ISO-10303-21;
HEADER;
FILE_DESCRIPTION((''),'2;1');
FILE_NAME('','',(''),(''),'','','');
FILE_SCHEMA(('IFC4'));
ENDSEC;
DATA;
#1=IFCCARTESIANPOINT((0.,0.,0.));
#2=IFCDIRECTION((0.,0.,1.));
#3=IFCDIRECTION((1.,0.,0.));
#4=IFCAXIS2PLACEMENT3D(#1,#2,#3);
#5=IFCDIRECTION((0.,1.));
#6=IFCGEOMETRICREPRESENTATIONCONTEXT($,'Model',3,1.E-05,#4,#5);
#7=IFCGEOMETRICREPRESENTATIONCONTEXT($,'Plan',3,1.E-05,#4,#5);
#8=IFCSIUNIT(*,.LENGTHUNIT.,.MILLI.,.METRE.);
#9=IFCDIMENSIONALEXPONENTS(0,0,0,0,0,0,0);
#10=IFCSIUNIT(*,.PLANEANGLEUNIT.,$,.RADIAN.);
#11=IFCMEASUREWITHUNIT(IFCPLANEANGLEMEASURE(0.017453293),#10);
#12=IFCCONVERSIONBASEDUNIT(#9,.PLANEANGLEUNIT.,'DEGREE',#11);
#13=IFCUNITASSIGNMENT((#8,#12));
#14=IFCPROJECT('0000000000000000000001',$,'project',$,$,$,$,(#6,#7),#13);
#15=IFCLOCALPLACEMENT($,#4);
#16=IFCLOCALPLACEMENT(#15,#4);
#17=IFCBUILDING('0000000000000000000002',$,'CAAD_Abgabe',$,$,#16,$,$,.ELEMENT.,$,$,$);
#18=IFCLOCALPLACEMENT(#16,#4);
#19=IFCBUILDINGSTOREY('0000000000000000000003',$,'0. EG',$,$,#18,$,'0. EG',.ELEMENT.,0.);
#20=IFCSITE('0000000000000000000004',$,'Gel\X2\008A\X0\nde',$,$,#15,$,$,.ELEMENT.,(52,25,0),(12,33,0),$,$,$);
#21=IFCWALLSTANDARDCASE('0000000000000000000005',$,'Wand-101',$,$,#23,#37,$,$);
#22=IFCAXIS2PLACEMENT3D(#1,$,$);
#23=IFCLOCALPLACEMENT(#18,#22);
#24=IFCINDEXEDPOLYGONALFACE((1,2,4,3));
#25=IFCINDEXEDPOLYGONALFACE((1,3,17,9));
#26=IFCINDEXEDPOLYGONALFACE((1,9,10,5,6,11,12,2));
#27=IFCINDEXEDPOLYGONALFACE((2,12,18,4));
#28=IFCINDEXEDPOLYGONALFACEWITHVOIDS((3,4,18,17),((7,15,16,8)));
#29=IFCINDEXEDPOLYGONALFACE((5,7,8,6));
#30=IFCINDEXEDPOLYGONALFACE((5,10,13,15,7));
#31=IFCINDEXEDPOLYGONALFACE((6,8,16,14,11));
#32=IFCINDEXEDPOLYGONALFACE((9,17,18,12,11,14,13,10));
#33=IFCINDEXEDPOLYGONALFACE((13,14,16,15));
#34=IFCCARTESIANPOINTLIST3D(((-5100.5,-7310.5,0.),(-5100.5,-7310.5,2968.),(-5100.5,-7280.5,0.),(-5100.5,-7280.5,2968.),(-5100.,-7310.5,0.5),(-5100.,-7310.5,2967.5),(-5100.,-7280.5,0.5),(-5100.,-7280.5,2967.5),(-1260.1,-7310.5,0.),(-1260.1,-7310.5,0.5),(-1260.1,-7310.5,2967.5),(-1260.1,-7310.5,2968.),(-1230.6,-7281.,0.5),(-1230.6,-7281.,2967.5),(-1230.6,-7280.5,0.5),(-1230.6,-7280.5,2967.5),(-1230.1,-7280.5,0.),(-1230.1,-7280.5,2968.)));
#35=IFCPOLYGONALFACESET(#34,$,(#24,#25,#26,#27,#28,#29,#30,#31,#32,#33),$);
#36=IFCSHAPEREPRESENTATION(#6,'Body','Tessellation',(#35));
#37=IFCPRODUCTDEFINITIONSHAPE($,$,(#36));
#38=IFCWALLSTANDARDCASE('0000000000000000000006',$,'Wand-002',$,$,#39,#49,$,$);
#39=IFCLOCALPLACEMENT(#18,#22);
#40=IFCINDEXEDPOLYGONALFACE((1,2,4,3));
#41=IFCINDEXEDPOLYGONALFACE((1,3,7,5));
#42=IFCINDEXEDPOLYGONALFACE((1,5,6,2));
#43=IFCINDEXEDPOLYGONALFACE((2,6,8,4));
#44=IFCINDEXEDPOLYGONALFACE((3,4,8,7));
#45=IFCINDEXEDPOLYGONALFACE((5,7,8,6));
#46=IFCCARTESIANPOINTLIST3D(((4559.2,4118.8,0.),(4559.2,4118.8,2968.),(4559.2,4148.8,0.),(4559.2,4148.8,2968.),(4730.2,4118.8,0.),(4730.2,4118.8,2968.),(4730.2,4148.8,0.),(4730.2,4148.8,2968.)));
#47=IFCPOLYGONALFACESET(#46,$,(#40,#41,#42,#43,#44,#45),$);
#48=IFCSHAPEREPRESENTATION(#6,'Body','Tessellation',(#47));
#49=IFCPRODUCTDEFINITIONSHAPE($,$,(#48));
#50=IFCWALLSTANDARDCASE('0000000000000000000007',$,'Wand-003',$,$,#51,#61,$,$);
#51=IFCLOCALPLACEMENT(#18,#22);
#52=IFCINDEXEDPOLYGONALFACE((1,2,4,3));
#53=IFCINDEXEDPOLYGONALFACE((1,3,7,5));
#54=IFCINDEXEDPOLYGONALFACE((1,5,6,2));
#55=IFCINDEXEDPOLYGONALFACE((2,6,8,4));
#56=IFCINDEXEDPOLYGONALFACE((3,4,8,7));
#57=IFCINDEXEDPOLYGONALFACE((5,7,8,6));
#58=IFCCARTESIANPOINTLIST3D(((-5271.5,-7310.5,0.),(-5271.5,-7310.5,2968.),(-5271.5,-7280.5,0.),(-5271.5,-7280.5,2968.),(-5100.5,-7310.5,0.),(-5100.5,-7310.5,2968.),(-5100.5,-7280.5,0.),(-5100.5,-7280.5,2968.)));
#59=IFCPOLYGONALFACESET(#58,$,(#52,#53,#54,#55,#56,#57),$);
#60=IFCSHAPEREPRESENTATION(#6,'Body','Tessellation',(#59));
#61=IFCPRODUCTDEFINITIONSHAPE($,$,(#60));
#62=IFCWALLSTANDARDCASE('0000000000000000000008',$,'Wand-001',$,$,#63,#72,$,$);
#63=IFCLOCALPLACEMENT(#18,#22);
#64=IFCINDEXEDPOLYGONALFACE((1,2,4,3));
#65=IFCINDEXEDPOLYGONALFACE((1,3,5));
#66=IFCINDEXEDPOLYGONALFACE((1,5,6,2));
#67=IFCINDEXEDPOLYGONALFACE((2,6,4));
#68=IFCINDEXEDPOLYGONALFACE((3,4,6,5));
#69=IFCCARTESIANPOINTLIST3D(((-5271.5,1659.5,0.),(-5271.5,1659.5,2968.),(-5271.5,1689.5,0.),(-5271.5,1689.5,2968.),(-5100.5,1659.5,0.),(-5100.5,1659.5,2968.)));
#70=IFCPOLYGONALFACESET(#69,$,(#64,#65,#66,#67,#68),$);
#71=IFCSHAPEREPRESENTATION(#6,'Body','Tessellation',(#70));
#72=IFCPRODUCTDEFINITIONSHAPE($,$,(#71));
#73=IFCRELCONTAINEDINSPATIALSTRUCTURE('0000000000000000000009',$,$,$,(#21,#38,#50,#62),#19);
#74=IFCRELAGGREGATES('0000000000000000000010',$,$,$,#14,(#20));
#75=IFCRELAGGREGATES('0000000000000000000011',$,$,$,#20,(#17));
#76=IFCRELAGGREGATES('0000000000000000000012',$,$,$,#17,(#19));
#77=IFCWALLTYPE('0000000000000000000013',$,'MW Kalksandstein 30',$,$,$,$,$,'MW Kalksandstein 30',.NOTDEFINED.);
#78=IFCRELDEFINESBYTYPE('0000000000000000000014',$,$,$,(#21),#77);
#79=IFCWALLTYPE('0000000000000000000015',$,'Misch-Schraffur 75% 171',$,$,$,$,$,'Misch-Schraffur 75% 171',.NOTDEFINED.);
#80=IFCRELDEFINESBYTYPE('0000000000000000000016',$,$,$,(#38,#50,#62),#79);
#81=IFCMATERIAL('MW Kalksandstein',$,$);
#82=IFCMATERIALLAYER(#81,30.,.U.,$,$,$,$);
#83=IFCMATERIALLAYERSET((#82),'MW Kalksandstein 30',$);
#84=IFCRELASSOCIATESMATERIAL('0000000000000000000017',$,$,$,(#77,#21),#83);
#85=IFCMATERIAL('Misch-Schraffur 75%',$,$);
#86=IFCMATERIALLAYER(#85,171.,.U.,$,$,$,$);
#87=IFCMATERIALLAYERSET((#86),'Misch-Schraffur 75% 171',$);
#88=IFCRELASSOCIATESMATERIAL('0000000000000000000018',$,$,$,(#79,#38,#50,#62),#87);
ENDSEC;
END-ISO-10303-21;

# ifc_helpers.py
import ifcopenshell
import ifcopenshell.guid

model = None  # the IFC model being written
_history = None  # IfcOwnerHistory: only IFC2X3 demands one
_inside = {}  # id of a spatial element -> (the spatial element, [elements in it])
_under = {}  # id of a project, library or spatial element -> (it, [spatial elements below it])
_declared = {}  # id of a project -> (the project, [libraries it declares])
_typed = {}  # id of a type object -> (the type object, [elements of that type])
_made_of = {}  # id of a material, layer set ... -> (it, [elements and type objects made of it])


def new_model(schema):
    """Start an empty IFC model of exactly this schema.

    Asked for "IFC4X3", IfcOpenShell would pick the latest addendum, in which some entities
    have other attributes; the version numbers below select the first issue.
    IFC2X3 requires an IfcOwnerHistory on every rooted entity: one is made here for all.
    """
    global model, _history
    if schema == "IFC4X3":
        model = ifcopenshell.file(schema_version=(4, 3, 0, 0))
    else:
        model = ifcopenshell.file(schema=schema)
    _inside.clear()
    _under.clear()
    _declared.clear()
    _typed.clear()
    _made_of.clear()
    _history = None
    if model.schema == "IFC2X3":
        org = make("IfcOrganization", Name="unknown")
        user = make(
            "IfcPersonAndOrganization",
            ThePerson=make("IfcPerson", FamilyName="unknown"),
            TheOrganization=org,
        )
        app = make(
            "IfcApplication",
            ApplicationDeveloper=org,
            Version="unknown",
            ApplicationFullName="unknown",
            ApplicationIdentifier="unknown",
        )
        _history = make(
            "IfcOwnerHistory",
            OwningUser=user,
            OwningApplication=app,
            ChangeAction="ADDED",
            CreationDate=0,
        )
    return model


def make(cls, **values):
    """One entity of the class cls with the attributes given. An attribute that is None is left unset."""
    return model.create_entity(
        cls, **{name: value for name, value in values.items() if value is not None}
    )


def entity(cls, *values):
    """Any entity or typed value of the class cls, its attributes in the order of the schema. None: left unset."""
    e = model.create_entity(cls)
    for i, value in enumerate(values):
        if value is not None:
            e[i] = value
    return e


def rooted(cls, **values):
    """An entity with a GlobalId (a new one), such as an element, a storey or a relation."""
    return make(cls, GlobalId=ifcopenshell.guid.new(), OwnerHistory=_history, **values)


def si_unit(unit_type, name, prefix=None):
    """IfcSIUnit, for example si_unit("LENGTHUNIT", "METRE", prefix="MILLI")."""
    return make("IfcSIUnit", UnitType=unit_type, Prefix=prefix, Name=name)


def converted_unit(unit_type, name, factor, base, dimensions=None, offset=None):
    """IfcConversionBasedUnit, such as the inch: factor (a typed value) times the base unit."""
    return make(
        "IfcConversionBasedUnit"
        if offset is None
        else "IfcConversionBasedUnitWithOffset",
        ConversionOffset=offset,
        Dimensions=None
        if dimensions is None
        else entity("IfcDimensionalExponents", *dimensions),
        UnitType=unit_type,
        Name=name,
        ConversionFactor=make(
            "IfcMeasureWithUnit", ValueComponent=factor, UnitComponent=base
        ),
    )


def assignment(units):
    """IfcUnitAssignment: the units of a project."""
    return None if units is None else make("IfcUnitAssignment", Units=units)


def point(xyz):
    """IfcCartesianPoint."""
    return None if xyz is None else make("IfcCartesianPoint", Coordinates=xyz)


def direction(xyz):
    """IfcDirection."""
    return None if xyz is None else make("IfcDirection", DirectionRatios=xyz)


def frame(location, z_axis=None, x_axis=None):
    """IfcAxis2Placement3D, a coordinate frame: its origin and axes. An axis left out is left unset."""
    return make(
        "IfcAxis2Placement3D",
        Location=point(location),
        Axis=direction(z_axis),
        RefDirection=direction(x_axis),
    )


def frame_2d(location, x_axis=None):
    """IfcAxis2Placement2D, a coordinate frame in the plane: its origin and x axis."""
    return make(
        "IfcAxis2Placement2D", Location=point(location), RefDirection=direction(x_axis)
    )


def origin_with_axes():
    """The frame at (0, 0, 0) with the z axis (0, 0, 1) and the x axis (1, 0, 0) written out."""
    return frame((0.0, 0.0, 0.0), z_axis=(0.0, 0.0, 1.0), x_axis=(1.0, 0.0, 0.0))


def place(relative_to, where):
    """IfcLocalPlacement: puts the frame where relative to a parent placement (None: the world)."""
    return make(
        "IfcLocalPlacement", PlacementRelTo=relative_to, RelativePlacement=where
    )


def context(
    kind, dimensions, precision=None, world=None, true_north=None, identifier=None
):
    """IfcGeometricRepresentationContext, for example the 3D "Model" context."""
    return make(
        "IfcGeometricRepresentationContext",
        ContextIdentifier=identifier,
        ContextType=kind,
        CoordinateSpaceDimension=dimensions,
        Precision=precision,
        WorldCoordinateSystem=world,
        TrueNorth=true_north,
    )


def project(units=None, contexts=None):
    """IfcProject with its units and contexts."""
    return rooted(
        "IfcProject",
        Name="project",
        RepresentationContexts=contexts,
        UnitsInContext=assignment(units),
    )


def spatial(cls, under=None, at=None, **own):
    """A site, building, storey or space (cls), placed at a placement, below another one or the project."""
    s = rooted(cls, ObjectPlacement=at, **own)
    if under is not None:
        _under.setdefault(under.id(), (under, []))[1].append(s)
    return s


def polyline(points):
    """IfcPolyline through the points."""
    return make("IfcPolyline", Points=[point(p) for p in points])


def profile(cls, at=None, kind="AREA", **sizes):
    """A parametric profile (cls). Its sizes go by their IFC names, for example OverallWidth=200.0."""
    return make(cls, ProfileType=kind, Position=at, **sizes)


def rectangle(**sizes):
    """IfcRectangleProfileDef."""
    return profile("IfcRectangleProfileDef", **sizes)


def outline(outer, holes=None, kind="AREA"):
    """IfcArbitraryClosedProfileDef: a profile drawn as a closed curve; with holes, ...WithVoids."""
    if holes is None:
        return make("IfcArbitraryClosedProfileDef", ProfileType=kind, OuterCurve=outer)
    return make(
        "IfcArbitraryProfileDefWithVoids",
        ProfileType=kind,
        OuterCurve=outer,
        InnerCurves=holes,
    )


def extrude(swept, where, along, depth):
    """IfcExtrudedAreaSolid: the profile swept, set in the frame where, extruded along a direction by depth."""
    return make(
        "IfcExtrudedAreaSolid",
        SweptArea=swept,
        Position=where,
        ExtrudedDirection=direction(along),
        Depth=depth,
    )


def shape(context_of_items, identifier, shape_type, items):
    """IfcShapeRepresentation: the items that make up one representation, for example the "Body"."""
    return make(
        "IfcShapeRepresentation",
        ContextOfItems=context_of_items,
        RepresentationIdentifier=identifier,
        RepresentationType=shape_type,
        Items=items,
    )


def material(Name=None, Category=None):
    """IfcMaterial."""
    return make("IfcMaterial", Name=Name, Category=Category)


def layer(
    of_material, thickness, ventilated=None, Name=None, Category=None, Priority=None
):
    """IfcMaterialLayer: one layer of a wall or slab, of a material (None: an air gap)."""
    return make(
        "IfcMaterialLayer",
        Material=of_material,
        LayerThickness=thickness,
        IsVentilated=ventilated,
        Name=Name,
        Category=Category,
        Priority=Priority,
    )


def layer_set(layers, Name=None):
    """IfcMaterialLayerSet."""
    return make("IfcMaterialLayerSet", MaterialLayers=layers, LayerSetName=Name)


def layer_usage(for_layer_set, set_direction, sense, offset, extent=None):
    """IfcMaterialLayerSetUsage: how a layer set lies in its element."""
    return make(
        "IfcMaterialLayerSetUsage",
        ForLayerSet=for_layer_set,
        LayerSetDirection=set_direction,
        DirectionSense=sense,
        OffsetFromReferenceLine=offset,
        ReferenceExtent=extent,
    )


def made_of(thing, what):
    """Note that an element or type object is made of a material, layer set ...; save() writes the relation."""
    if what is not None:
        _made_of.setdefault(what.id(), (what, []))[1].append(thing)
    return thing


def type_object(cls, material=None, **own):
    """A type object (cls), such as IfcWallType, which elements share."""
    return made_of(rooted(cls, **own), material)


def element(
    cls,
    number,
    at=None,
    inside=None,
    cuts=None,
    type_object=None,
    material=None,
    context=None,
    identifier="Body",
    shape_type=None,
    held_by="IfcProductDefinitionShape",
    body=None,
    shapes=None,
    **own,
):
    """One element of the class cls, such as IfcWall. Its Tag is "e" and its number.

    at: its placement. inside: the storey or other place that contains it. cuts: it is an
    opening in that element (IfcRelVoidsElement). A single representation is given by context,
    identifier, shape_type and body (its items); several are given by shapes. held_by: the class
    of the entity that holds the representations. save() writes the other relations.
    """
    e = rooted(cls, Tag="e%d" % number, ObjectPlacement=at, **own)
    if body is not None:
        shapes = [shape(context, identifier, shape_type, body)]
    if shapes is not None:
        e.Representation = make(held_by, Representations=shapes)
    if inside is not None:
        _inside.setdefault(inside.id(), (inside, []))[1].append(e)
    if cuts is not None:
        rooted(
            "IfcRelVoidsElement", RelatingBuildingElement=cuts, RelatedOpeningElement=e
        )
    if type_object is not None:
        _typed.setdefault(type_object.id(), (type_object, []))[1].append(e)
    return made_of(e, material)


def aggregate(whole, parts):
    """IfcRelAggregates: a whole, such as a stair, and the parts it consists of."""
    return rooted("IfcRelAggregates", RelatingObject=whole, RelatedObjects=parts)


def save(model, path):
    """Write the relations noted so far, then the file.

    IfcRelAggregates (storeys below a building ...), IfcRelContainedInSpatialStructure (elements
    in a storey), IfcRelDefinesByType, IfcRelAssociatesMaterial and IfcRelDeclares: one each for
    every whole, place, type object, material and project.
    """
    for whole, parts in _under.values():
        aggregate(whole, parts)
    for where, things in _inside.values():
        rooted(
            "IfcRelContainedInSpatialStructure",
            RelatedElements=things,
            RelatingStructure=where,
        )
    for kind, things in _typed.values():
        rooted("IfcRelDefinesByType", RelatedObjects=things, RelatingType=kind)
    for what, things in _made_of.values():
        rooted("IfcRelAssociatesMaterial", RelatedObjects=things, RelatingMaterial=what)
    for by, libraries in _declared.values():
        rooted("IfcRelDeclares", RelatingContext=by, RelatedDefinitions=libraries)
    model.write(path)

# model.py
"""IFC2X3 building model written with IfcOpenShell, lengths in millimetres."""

from ifc_helpers import new_model, entity, si_unit, converted_unit, direction, frame, frame_2d, origin_with_axes, place, context, project, spatial, polyline, rectangle, outline, extrude, material, layer, layer_set, layer_usage, type_object, element, save


model = new_model("IFC2X3")

# Units and contexts
model_context = context("Model", 3, precision=1e-05, world=origin_with_axes(), true_north=direction((0.0, 1.0)))
plan_context = context("Plan", 3, precision=1e-05, world=origin_with_axes(), true_north=direction((0.0, 1.0)))
ifc_project = project(units=[si_unit("LENGTHUNIT", "METRE", prefix="MILLI"), converted_unit("PLANEANGLEUNIT", "DEGREE", entity("IfcPlaneAngleMeasure", 0.017453293), si_unit("PLANEANGLEUNIT", "RADIAN"), dimensions=[0, 0, 0, 0, 0, 0, 0])], contexts=[model_context, plan_context])

# Site, building, storey
site_placement = place(None, origin_with_axes())
site = spatial("IfcSite", under=ifc_project, at=site_placement, Name="Gel\u008ande", CompositionType="ELEMENT", RefLatitude=(52, 25, 0), RefLongitude=(12, 33, 0))
building_placement = place(site_placement, origin_with_axes())
building = spatial("IfcBuilding", under=site, at=building_placement, Name="CAAD_Abgabe", CompositionType="ELEMENT")
storey_placement = place(building_placement, origin_with_axes())
storey = spatial("IfcBuildingStorey", under=building, at=storey_placement, Name="0. EG", LongName="0. EG", CompositionType="ELEMENT", Elevation=0.0)

# Shared definitions
ifc_material_1 = material(Name="Misch-Schraffur 75%")

# Wall, opening
ifc_material_2 = material(Name="MW Kalksandstein")
ifc_layer_1 = layer(ifc_material_2, 30.0, ventilated="UNKNOWN")
ifc_layer_set_1 = layer_set([ifc_layer_1], Name="MW Kalksandstein 30")
wall_type_1 = type_object("IfcWallType", Name="MW Kalksandstein 30", ElementType="MW Kalksandstein 30", PredefinedType="NOTDEFINED", material=ifc_layer_set_1)
ifc_layer_usage_1 = layer_usage(ifc_layer_set_1, "AXIS2", "NEGATIVE", 0.0)
wall_1_placement = place(storey_placement, frame((-5100.5, -7280.5, 0.0), z_axis=(0.0, 0.0, 1.0), x_axis=(1.0, 0.0, 0.0)))
wall_1 = element("IfcWallStandardCase", 1, at=wall_1_placement, inside=storey, type_object=wall_type_1, material=ifc_layer_usage_1, Name="Wand-101", context=model_context, shape_type="SweptSolid", body=[
    extrude(outline(polyline([(0.0, -30.0), (3840.4, -30.0), (3870.4, 0.0), (0.0, 0.0), (0.0, -30.0)])), origin_with_axes(), (0.0, 0.0, 1.0), 2968.0),
])
opening_1_placement = place(wall_1_placement, frame((1935.2, -30.0, 0.0), z_axis=(0.0, 0.0, 1.0), x_axis=(1.0, 0.0, 0.0)))
element("IfcOpeningElement", 2, at=opening_1_placement, cuts=wall_1, ObjectType="Opening", context=model_context, shape_type="SweptSolid", body=[
    extrude(rectangle(XDim=3869.4, YDim=2967.0, at=frame_2d((0.0, 1484.0), x_axis=(1.0, 0.0))), frame((0.0, 0.0, 0.0), z_axis=(0.0, 1.0, 0.0), x_axis=(-1.0, 0.0, 0.0)), (0.0, 0.0, 1.0), 30.0),
])

# Walls
ifc_layer_2 = layer(ifc_material_1, 171.0, ventilated="UNKNOWN")
ifc_layer_set_2 = layer_set([ifc_layer_2], Name="Misch-Schraffur 75% 171")
ifc_layer_usage_2 = layer_usage(ifc_layer_set_2, "AXIS2", "NEGATIVE", 0.0)
wall_type_2 = type_object("IfcWallType", Name="Misch-Schraffur 75% 171", ElementType="Misch-Schraffur 75% 171", PredefinedType="NOTDEFINED", material=ifc_layer_set_2)
wall_2_placement = place(storey_placement, frame((4730.2, 4148.8, 0.0), z_axis=(0.0, 0.0, 1.0), x_axis=(-0.000013, -1.0, 0.0)))
element("IfcWallStandardCase", 3, at=wall_2_placement, inside=storey, type_object=wall_type_2, material=ifc_layer_usage_2, Name="Wand-002", context=model_context, shape_type="SweptSolid", body=[
    extrude(outline(polyline([(0.0, -171.0), (30.0, -171.0), (30.0, 0.0), (0.0, 0.0), (0.0, -171.0)])), origin_with_axes(), (0.0, 0.0, 1.0), 2968.0),
])
ifc_layer_usage_3 = layer_usage(ifc_layer_set_2, "AXIS2", "NEGATIVE", 0.0)
wall_3_placement = place(storey_placement, frame((-5271.5, -7310.5, 0.0), z_axis=(0.0, 0.0, 1.0), x_axis=(0.0, 1.0, 0.0)))
element("IfcWallStandardCase", 4, at=wall_3_placement, inside=storey, type_object=wall_type_2, material=ifc_layer_usage_3, Name="Wand-003", context=model_context, shape_type="SweptSolid", body=[
    extrude(outline(polyline([(0.0, -171.0), (30.0, -171.0), (30.0, 0.0), (0.0, 0.0), (0.0, -171.0)])), origin_with_axes(), (0.0, 0.0, 1.0), 2968.0),
])
ifc_layer_usage_4 = layer_usage(ifc_layer_set_2, "AXIS2", "NEGATIVE", 0.0)
wall_4_placement = place(storey_placement, frame((-5271.5, 1659.5, 0.0), z_axis=(0.0, 0.0, 1.0), x_axis=(0.0, 1.0, 0.0)))
element("IfcWallStandardCase", 5, at=wall_4_placement, inside=storey, type_object=wall_type_2, material=ifc_layer_usage_4, Name="Wand-001", context=model_context, shape_type="SweptSolid", body=[
    extrude(outline(polyline([(0.0, -171.0), (0.0, -171.0), (30.0, 0.0), (0.0, 0.0), (0.0, -171.0)])), origin_with_axes(), (0.0, 0.0, 1.0), 2968.0),
])

save(model, "model.ifc")
